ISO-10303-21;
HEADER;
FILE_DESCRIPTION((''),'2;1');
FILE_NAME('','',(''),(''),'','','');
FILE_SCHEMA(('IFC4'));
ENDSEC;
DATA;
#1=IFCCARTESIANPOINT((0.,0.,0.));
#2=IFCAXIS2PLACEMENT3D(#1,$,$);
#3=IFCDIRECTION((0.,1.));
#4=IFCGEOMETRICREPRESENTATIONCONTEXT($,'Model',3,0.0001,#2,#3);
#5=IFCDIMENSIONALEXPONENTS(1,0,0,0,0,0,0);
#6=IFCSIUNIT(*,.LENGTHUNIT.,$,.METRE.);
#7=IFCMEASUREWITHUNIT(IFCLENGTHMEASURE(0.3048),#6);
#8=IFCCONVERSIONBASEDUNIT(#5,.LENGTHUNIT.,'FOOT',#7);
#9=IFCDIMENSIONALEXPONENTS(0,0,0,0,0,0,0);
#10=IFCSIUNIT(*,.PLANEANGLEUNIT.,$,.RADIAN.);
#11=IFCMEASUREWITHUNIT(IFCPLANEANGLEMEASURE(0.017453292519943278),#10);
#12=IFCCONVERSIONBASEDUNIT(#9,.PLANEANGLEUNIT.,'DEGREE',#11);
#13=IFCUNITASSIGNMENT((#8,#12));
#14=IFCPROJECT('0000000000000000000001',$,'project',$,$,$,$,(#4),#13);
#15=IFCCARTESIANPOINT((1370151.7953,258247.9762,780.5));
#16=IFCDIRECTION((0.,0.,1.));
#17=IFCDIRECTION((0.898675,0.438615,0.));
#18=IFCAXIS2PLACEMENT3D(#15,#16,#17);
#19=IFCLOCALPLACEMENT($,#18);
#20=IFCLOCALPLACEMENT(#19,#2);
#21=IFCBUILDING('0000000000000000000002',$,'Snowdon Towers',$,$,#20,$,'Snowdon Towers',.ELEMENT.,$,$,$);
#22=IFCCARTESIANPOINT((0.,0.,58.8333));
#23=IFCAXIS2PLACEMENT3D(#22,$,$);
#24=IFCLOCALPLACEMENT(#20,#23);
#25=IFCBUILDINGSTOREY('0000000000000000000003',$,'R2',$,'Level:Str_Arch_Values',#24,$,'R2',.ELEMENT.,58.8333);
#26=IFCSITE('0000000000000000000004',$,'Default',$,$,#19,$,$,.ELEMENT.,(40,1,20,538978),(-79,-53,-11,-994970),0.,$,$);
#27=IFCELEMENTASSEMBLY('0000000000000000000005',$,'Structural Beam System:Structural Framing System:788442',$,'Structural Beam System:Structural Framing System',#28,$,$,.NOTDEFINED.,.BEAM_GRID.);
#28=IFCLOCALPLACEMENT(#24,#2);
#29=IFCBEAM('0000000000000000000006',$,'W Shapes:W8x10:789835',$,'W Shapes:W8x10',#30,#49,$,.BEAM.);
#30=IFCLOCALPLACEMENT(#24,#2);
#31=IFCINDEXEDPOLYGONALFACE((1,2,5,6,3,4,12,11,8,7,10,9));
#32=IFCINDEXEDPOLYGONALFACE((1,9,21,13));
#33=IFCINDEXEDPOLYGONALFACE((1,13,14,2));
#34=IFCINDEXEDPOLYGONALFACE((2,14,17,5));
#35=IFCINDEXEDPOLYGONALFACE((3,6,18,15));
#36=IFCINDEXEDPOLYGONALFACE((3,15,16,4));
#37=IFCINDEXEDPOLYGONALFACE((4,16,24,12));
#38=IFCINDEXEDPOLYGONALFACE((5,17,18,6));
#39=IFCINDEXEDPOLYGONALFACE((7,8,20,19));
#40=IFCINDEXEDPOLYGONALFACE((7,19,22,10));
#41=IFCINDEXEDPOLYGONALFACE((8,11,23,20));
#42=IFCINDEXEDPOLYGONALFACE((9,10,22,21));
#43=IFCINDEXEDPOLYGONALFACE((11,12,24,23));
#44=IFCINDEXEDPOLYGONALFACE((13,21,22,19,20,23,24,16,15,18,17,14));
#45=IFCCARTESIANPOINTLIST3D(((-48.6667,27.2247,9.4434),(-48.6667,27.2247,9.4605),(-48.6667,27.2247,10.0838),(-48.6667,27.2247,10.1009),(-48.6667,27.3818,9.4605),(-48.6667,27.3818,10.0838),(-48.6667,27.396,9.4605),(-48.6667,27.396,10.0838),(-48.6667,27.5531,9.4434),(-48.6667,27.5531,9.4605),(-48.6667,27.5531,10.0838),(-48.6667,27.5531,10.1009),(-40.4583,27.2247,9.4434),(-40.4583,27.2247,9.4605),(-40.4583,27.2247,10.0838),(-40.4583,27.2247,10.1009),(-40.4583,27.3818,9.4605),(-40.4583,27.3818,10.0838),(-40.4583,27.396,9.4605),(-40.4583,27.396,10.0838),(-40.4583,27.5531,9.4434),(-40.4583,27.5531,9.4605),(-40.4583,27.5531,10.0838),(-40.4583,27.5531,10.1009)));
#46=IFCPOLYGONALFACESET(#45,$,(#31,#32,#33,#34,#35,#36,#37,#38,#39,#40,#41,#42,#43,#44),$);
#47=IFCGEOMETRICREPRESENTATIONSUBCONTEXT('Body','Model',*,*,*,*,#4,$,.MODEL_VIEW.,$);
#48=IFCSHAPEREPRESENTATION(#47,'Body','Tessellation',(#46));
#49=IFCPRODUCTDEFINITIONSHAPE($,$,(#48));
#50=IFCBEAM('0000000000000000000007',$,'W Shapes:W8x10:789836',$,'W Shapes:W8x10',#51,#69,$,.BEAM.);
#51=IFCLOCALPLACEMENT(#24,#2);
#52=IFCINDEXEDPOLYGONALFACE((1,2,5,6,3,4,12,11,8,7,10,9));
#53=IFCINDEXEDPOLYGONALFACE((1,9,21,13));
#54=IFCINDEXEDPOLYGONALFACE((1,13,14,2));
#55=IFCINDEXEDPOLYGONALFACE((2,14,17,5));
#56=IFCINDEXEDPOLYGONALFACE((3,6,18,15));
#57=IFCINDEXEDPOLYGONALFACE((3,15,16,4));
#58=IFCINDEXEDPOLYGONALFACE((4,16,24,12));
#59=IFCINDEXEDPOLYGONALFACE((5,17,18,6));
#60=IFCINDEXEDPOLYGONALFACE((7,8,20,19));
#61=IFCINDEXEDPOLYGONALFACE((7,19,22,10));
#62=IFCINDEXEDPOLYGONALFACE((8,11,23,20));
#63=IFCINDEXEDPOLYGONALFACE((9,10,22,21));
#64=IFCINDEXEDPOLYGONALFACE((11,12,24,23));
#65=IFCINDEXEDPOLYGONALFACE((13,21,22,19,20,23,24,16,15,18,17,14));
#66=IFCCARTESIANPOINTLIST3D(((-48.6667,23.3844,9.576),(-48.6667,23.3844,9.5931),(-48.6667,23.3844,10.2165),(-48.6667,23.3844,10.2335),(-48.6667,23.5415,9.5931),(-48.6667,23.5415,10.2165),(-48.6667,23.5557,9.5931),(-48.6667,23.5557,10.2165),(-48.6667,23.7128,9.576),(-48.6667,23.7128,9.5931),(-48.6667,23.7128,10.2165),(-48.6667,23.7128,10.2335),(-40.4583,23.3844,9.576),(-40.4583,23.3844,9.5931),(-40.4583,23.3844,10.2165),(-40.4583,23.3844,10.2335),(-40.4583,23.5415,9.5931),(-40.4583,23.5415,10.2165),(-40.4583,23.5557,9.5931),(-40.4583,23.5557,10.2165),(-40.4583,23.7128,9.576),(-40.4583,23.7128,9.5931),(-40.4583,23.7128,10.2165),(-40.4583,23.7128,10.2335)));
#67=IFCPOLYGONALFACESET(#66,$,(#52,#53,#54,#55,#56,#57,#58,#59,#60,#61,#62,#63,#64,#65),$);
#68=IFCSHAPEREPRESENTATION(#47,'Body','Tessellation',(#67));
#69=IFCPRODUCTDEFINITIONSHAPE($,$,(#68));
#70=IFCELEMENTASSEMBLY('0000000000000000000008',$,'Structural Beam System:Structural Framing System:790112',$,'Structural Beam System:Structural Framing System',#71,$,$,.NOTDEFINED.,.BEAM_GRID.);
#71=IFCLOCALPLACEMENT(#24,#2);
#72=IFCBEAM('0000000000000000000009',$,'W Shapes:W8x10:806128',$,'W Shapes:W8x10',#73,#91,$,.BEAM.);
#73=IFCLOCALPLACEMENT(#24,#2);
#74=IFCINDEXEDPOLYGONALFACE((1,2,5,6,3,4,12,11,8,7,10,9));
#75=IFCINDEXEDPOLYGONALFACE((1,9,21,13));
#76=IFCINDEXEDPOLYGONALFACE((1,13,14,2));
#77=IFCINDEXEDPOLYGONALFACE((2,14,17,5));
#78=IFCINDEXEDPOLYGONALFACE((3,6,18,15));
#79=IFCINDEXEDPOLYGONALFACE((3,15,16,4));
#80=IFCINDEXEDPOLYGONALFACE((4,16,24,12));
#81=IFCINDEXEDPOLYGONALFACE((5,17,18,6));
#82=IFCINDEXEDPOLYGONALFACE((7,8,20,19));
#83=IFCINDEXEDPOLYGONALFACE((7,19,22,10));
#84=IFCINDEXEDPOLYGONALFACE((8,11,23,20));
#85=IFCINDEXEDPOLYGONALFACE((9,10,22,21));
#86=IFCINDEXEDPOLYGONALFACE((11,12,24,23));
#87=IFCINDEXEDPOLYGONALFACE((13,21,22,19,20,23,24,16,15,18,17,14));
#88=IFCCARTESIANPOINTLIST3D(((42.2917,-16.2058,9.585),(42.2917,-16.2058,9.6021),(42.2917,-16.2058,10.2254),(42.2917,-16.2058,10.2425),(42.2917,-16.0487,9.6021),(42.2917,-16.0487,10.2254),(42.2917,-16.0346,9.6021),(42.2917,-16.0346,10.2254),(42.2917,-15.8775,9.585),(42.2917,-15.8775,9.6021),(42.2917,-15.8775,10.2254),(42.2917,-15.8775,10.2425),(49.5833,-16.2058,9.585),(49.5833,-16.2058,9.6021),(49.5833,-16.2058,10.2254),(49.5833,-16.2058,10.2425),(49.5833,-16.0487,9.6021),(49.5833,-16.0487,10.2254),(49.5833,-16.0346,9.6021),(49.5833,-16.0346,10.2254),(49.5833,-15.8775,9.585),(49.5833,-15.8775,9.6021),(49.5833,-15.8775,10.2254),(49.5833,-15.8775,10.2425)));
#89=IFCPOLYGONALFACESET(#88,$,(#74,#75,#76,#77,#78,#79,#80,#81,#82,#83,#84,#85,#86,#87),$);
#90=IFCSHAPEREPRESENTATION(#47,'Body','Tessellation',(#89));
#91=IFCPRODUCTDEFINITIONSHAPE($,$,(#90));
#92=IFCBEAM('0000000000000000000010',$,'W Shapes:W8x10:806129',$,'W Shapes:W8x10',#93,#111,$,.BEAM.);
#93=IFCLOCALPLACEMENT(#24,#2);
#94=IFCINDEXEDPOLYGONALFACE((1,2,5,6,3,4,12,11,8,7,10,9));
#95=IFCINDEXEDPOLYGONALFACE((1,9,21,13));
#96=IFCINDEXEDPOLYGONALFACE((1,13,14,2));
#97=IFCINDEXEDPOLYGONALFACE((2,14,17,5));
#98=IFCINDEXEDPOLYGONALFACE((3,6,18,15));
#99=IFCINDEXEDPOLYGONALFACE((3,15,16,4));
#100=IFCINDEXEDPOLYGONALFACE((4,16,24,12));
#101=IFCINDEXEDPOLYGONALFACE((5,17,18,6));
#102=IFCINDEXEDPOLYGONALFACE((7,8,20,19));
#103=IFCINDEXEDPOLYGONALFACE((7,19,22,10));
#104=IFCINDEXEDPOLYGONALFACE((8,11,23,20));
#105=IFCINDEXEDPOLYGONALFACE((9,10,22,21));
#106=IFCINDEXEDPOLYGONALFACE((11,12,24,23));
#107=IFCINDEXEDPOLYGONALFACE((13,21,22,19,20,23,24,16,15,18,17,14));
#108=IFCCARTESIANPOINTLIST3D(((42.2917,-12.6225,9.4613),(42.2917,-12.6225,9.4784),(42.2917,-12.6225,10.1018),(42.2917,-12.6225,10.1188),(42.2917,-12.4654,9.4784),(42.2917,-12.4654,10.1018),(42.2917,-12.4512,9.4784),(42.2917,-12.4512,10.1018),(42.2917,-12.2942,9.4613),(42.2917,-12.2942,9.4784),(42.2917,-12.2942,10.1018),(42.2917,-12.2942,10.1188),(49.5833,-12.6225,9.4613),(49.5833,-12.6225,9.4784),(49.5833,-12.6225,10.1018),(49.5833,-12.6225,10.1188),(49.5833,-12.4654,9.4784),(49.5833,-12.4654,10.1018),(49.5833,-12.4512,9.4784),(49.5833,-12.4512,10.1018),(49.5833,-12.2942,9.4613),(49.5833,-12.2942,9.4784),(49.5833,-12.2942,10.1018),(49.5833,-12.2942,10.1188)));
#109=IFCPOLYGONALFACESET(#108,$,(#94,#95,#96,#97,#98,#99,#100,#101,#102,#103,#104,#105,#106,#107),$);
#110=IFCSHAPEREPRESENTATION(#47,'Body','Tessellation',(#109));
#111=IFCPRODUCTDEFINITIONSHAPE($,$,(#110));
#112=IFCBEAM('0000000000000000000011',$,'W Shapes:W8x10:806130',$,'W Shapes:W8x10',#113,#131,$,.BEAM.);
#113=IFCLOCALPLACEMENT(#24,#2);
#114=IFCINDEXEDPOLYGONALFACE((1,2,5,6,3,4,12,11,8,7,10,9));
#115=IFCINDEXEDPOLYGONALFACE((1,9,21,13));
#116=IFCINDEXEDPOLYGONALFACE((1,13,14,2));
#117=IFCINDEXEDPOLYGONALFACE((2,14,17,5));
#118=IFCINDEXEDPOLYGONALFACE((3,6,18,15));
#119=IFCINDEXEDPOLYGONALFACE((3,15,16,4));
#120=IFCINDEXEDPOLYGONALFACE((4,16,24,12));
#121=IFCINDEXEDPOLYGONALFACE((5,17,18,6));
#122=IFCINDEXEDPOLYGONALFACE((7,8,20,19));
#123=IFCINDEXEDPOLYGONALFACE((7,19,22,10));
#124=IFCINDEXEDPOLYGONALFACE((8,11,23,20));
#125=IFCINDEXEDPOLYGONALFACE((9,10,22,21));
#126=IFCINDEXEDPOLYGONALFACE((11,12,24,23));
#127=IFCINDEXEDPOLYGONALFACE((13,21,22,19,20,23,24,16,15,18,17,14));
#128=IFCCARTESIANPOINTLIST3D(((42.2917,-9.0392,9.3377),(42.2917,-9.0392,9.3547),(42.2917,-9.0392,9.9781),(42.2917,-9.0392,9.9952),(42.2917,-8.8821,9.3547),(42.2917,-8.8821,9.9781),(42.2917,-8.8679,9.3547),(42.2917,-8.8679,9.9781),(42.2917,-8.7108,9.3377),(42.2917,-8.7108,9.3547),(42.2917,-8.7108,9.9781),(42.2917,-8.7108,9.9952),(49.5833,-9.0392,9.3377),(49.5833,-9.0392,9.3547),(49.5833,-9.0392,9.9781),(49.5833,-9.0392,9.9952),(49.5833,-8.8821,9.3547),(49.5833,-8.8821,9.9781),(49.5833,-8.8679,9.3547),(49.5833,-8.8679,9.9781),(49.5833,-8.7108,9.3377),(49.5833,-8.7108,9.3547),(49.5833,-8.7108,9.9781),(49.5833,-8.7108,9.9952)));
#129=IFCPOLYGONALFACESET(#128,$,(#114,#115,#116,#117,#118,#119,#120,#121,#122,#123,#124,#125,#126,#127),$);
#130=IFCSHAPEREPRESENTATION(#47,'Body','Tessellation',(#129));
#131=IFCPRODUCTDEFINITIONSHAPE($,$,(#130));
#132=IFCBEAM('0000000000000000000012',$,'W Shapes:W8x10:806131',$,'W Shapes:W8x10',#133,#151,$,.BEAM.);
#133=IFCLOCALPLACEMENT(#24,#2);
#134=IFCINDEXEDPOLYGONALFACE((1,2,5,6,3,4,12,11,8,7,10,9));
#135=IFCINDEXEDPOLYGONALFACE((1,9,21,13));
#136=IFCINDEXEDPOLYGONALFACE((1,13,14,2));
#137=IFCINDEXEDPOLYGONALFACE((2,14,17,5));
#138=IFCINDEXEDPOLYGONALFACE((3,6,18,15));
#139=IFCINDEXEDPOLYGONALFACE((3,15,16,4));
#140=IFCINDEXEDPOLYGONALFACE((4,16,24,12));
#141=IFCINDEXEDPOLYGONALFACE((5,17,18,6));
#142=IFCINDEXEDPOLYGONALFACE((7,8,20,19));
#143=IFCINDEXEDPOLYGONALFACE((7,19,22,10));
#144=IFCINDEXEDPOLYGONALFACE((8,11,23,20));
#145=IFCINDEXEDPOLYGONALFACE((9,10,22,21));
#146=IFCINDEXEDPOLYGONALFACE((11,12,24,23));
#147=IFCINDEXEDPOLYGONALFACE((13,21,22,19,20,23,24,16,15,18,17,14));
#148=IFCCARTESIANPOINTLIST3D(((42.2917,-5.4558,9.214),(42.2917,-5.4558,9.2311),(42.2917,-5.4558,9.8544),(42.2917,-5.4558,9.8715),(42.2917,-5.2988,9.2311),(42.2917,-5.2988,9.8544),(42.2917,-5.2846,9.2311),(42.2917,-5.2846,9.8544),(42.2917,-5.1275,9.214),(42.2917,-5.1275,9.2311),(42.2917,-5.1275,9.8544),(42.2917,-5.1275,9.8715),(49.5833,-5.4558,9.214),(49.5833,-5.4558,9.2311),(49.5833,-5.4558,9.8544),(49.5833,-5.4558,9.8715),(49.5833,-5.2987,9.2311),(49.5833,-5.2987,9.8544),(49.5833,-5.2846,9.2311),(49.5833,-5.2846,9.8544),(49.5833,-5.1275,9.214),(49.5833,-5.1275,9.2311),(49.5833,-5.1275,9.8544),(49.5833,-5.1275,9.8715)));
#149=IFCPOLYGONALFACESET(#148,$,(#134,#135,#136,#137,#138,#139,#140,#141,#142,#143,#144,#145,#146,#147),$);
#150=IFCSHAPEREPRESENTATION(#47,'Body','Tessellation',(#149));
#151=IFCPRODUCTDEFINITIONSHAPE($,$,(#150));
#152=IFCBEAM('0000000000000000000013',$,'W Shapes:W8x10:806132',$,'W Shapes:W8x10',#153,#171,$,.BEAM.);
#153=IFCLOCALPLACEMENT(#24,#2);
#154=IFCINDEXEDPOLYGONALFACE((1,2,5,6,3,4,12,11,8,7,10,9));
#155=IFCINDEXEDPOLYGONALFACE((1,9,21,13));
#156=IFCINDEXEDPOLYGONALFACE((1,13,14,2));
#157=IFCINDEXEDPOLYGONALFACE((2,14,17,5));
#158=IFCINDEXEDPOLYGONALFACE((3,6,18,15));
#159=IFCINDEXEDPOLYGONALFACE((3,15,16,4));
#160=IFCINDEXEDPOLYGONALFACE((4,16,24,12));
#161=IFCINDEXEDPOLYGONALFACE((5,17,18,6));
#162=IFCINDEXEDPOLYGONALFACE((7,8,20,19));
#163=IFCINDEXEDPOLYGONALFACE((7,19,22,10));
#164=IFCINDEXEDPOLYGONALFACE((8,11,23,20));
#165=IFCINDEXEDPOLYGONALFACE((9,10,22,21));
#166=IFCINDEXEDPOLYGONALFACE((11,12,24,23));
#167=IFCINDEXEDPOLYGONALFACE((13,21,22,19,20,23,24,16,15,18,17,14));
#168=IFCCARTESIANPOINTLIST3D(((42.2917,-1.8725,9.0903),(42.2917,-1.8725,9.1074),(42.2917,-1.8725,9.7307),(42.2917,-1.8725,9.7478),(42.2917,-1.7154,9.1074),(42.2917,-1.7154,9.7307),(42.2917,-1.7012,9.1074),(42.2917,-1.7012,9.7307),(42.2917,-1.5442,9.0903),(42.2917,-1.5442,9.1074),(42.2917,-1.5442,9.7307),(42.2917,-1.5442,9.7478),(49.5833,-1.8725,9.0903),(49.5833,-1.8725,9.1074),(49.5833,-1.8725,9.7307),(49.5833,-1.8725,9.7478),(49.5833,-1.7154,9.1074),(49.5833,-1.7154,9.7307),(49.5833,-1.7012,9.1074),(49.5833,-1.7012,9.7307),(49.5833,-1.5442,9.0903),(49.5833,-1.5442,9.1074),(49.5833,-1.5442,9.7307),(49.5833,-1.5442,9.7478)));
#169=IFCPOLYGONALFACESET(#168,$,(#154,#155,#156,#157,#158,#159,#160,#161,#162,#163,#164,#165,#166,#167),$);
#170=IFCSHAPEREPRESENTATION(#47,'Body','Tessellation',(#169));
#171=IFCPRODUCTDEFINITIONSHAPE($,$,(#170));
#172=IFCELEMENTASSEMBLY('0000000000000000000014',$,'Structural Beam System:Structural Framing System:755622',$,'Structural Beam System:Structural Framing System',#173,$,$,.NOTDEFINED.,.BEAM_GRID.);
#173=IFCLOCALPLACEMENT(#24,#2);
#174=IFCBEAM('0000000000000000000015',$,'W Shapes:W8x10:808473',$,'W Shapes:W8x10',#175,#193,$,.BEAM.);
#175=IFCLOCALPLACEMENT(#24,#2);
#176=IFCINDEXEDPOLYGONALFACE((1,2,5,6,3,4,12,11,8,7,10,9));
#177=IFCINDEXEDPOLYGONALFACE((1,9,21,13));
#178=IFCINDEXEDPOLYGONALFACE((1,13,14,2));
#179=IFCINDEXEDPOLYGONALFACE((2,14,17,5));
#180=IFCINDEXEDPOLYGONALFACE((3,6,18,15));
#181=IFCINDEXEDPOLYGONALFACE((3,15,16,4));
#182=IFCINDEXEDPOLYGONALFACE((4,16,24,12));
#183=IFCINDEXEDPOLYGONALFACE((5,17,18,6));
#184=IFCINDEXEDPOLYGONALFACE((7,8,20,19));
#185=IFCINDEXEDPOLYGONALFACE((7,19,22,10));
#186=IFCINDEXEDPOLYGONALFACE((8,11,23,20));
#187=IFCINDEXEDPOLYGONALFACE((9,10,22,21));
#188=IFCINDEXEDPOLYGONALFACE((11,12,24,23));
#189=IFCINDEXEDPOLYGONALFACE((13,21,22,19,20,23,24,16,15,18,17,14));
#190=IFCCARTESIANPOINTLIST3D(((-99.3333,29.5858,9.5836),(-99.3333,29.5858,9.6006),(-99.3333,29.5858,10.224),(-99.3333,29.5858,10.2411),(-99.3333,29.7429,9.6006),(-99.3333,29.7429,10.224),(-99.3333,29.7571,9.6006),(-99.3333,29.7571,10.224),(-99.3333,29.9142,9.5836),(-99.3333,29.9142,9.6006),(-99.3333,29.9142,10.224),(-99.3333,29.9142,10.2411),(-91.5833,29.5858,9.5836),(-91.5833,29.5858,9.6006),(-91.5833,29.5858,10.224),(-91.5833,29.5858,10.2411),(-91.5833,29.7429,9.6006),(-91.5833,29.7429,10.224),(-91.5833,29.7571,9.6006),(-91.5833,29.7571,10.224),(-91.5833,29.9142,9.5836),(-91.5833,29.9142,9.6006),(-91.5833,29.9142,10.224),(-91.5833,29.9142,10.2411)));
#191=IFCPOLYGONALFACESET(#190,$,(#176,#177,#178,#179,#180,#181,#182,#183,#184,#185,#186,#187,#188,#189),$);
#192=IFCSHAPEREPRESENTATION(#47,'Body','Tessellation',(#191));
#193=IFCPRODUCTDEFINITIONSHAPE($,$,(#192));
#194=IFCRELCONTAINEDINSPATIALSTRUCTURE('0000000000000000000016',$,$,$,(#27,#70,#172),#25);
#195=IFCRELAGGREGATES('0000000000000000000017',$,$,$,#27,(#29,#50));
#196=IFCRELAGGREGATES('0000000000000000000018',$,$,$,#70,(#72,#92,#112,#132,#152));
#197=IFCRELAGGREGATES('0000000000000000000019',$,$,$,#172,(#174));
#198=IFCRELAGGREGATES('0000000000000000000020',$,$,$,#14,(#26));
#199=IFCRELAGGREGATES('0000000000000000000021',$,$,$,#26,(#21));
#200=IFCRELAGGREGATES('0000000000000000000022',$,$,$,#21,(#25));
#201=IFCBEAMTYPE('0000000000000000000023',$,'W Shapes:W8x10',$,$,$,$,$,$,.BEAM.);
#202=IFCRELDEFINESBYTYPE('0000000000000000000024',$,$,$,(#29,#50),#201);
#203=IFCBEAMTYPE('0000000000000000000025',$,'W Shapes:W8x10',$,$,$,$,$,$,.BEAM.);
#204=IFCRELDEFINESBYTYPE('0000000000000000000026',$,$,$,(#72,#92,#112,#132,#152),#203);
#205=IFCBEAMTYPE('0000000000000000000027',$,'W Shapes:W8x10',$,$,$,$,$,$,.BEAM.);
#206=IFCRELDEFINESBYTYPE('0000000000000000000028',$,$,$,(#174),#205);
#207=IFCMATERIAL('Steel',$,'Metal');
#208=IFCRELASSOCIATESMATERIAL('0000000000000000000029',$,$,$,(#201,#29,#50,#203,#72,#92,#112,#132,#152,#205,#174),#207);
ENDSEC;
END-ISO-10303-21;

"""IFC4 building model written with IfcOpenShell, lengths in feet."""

from ifc_helpers import new_model, entity, si_unit, converted_unit, direction, frame, origin, place, context, subcontext, project, spatial, indexed_curve, outline, extrude, source, transform, mapped, material, type_object, type_shapes, element, aggregate, save


model = new_model("IFC4")

# Units and contexts
model_context = context("Model", 3, precision=0.0001, world=origin(), true_north=direction((0.0, 1.0)))
body_context = subcontext(model_context, "Body", "Model", "MODEL_VIEW")
ifc_project = project(units=[converted_unit("LENGTHUNIT", "FOOT", entity("IfcLengthMeasure", 0.3048), si_unit("LENGTHUNIT", "METRE"), dimensions=[1, 0, 0, 0, 0, 0, 0]), converted_unit("PLANEANGLEUNIT", "DEGREE", entity("IfcPlaneAngleMeasure", 0.017453292519943278), si_unit("PLANEANGLEUNIT", "RADIAN"), dimensions=[0, 0, 0, 0, 0, 0, 0])], contexts=[model_context])

# Site, building, storey
site_placement = place(None, frame((1370151.7953, 258247.9762, 780.5), z_axis=(0.0, 0.0, 1.0), x_axis=(0.898675, 0.438615, 0.0)))
site = spatial("IfcSite", under=ifc_project, at=site_placement, Name="Default", CompositionType="ELEMENT", RefLatitude=(40, 1, 20, 538978), RefLongitude=(-79, -53, -11, -994970), RefElevation=0.0)
building_placement = place(site_placement, origin())
building = spatial("IfcBuilding", under=site, at=building_placement, Name="Snowdon Towers", LongName="Snowdon Towers", CompositionType="ELEMENT")
storey_placement = place(building_placement, frame((0.0, 0.0, 58.8333)))
storey = spatial("IfcBuildingStorey", under=building, at=storey_placement, Name="R2", ObjectType="Level:Str_Arch_Values", LongName="R2", CompositionType="ELEMENT", Elevation=58.8333)

# Element assemblies, beams
ifc_material_1 = material(Name="Steel", Category="Metal")
assembly_1_placement = place(storey_placement, origin())
assembly_1 = element("IfcElementAssembly", 1, at=assembly_1_placement, inside=storey, Name="Structural Beam System:Structural Framing System:788442", ObjectType="Structural Beam System:Structural Framing System", AssemblyPlace="NOTDEFINED", PredefinedType="BEAM_GRID")
beam_type_1 = type_object("IfcBeamType", Name="W Shapes:W8x10", PredefinedType="BEAM", material=ifc_material_1)
shared_shape_1 = source(origin(), body_context, "Body", "SweptSolid", [
    extrude(outline(indexed_curve([(-0.1642, -0.3117), (-0.1642, -0.3288), (0.1642, -0.3288), (0.1642, -0.3117), (0.0071, -0.3117), (0.0071, 0.3117), (0.1642, 0.3117), (0.1642, 0.3287), (-0.1642, 0.3287), (-0.1642, 0.3117), (-0.0071, 0.3117), (-0.0071, -0.3117), (-0.1642, -0.3117)], self_intersect=False)), frame((-4.1042, 0.0, 0.0), z_axis=(-1.0, 0.0, 0.0), x_axis=(0.0, -1.0, 0.0)), (0.0, 0.0, -1.0), 8.2083),
])
type_shapes(beam_type_1, [shared_shape_1])
beam_1_placement = place(assembly_1_placement, frame((-44.5625, 27.3889, 9.7721)))
beam_1 = element("IfcBeam", 2, at=beam_1_placement, type_object=beam_type_1, material=ifc_material_1, Name="W Shapes:W8x10:789835", ObjectType="W Shapes:W8x10", PredefinedType="BEAM", context=body_context, shape_type="MappedRepresentation", body=[
    mapped(shared_shape_1, transform((0.0, 0.0, 0.0), scale=1.0)),
])
beam_2_placement = place(assembly_1_placement, frame((-44.5625, 23.5486, 9.9048)))
beam_2 = element("IfcBeam", 3, at=beam_2_placement, type_object=beam_type_1, material=ifc_material_1, Name="W Shapes:W8x10:789836", ObjectType="W Shapes:W8x10", PredefinedType="BEAM", context=body_context, shape_type="MappedRepresentation", body=[
    mapped(shared_shape_1, transform((0.0, 0.0, 0.0), scale=1.0)),
])
aggregate(assembly_1, [beam_1, beam_2])
assembly_2_placement = place(storey_placement, origin())
assembly_2 = element("IfcElementAssembly", 4, at=assembly_2_placement, inside=storey, Name="Structural Beam System:Structural Framing System:790112", ObjectType="Structural Beam System:Structural Framing System", AssemblyPlace="NOTDEFINED", PredefinedType="BEAM_GRID")
beam_type_2 = type_object("IfcBeamType", Name="W Shapes:W8x10", PredefinedType="BEAM", material=ifc_material_1)
shared_shape_2 = source(origin(), body_context, "Body", "SweptSolid", [
    extrude(outline(indexed_curve([(-0.1642, -0.3117), (-0.1642, -0.3288), (0.1642, -0.3288), (0.1642, -0.3117), (0.0071, -0.3117), (0.0071, 0.3117), (0.1642, 0.3117), (0.1642, 0.3287), (-0.1642, 0.3287), (-0.1642, 0.3117), (-0.0071, 0.3117), (-0.0071, -0.3117), (-0.1642, -0.3117)], self_intersect=False)), frame((-3.6458, 0.0, 0.0), z_axis=(-1.0, 0.0, 0.0), x_axis=(0.0, -1.0, 0.0)), (0.0, 0.0, -1.0), 7.2917),
])
type_shapes(beam_type_2, [shared_shape_2])
beam_3_placement = place(assembly_2_placement, frame((45.9375, -16.0417, 9.9138), z_axis=(0.0, 0.0, 1.0), x_axis=(-1.0, 0.0, 0.0)))
beam_3 = element("IfcBeam", 5, at=beam_3_placement, type_object=beam_type_2, material=ifc_material_1, Name="W Shapes:W8x10:806128", ObjectType="W Shapes:W8x10", PredefinedType="BEAM", context=body_context, shape_type="MappedRepresentation", body=[
    mapped(shared_shape_2, transform((0.0, 0.0, 0.0), scale=1.0)),
])
beam_4_placement = place(assembly_2_placement, frame((45.9375, -12.4583, 9.7901), z_axis=(0.0, 0.0, 1.0), x_axis=(-1.0, 0.0, 0.0)))
beam_4 = element("IfcBeam", 6, at=beam_4_placement, type_object=beam_type_2, material=ifc_material_1, Name="W Shapes:W8x10:806129", ObjectType="W Shapes:W8x10", PredefinedType="BEAM", context=body_context, shape_type="MappedRepresentation", body=[
    mapped(shared_shape_2, transform((0.0, 0.0, 0.0), scale=1.0)),
])
beam_5_placement = place(assembly_2_placement, frame((45.9375, -8.875, 9.6664), z_axis=(0.0, 0.0, 1.0), x_axis=(-1.0, 0.0, 0.0)))
beam_5 = element("IfcBeam", 7, at=beam_5_placement, type_object=beam_type_2, material=ifc_material_1, Name="W Shapes:W8x10:806130", ObjectType="W Shapes:W8x10", PredefinedType="BEAM", context=body_context, shape_type="MappedRepresentation", body=[
    mapped(shared_shape_2, transform((0.0, 0.0, 0.0), scale=1.0)),
])
beam_6_placement = place(assembly_2_placement, frame((45.9375, -5.2917, 9.5427), z_axis=(0.0, 0.0, 1.0), x_axis=(-1.0, 0.0, 0.0)))
beam_6 = element("IfcBeam", 8, at=beam_6_placement, type_object=beam_type_2, material=ifc_material_1, Name="W Shapes:W8x10:806131", ObjectType="W Shapes:W8x10", PredefinedType="BEAM", context=body_context, shape_type="MappedRepresentation", body=[
    mapped(shared_shape_2, transform((0.0, 0.0, 0.0), scale=1.0)),
])
beam_7_placement = place(assembly_2_placement, frame((45.9375, -1.7083, 9.4191), z_axis=(0.0, 0.0, 1.0), x_axis=(-1.0, 0.0, 0.0)))
beam_7 = element("IfcBeam", 9, at=beam_7_placement, type_object=beam_type_2, material=ifc_material_1, Name="W Shapes:W8x10:806132", ObjectType="W Shapes:W8x10", PredefinedType="BEAM", context=body_context, shape_type="MappedRepresentation", body=[
    mapped(shared_shape_2, transform((0.0, 0.0, 0.0), scale=1.0)),
])
aggregate(assembly_2, [beam_3, beam_4, beam_5, beam_6, beam_7])

# Element assembly, beam
assembly_3_placement = place(storey_placement, origin())
assembly_3 = element("IfcElementAssembly", 10, at=assembly_3_placement, inside=storey, Name="Structural Beam System:Structural Framing System:755622", ObjectType="Structural Beam System:Structural Framing System", AssemblyPlace="NOTDEFINED", PredefinedType="BEAM_GRID")
beam_type_3 = type_object("IfcBeamType", Name="W Shapes:W8x10", PredefinedType="BEAM", material=ifc_material_1)
shared_shape_3 = source(origin(), body_context, "Body", "SweptSolid", [
    extrude(outline(indexed_curve([(-0.1642, -0.3117), (-0.1642, -0.3288), (0.1642, -0.3288), (0.1642, -0.3117), (0.0071, -0.3117), (0.0071, 0.3117), (0.1642, 0.3117), (0.1642, 0.3287), (-0.1642, 0.3287), (-0.1642, 0.3117), (-0.0071, 0.3117), (-0.0071, -0.3117), (-0.1642, -0.3117)], self_intersect=False)), frame((-3.875, 0.0, 0.0), z_axis=(-1.0, 0.0, 0.0), x_axis=(0.0, -1.0, 0.0)), (0.0, 0.0, -1.0), 7.75),
])
type_shapes(beam_type_3, [shared_shape_3])
beam_8_placement = place(assembly_3_placement, frame((-95.4583, 29.75, 9.9123), z_axis=(0.0, 0.0, 1.0), x_axis=(-1.0, 0.0, 0.0)))
beam_8 = element("IfcBeam", 11, at=beam_8_placement, type_object=beam_type_3, material=ifc_material_1, Name="W Shapes:W8x10:808473", ObjectType="W Shapes:W8x10", PredefinedType="BEAM", context=body_context, shape_type="MappedRepresentation", body=[
    mapped(shared_shape_3, transform((0.0, 0.0, 0.0), scale=1.0)),
])
aggregate(assembly_3, [beam_8])

save(model, "model.ifc")
